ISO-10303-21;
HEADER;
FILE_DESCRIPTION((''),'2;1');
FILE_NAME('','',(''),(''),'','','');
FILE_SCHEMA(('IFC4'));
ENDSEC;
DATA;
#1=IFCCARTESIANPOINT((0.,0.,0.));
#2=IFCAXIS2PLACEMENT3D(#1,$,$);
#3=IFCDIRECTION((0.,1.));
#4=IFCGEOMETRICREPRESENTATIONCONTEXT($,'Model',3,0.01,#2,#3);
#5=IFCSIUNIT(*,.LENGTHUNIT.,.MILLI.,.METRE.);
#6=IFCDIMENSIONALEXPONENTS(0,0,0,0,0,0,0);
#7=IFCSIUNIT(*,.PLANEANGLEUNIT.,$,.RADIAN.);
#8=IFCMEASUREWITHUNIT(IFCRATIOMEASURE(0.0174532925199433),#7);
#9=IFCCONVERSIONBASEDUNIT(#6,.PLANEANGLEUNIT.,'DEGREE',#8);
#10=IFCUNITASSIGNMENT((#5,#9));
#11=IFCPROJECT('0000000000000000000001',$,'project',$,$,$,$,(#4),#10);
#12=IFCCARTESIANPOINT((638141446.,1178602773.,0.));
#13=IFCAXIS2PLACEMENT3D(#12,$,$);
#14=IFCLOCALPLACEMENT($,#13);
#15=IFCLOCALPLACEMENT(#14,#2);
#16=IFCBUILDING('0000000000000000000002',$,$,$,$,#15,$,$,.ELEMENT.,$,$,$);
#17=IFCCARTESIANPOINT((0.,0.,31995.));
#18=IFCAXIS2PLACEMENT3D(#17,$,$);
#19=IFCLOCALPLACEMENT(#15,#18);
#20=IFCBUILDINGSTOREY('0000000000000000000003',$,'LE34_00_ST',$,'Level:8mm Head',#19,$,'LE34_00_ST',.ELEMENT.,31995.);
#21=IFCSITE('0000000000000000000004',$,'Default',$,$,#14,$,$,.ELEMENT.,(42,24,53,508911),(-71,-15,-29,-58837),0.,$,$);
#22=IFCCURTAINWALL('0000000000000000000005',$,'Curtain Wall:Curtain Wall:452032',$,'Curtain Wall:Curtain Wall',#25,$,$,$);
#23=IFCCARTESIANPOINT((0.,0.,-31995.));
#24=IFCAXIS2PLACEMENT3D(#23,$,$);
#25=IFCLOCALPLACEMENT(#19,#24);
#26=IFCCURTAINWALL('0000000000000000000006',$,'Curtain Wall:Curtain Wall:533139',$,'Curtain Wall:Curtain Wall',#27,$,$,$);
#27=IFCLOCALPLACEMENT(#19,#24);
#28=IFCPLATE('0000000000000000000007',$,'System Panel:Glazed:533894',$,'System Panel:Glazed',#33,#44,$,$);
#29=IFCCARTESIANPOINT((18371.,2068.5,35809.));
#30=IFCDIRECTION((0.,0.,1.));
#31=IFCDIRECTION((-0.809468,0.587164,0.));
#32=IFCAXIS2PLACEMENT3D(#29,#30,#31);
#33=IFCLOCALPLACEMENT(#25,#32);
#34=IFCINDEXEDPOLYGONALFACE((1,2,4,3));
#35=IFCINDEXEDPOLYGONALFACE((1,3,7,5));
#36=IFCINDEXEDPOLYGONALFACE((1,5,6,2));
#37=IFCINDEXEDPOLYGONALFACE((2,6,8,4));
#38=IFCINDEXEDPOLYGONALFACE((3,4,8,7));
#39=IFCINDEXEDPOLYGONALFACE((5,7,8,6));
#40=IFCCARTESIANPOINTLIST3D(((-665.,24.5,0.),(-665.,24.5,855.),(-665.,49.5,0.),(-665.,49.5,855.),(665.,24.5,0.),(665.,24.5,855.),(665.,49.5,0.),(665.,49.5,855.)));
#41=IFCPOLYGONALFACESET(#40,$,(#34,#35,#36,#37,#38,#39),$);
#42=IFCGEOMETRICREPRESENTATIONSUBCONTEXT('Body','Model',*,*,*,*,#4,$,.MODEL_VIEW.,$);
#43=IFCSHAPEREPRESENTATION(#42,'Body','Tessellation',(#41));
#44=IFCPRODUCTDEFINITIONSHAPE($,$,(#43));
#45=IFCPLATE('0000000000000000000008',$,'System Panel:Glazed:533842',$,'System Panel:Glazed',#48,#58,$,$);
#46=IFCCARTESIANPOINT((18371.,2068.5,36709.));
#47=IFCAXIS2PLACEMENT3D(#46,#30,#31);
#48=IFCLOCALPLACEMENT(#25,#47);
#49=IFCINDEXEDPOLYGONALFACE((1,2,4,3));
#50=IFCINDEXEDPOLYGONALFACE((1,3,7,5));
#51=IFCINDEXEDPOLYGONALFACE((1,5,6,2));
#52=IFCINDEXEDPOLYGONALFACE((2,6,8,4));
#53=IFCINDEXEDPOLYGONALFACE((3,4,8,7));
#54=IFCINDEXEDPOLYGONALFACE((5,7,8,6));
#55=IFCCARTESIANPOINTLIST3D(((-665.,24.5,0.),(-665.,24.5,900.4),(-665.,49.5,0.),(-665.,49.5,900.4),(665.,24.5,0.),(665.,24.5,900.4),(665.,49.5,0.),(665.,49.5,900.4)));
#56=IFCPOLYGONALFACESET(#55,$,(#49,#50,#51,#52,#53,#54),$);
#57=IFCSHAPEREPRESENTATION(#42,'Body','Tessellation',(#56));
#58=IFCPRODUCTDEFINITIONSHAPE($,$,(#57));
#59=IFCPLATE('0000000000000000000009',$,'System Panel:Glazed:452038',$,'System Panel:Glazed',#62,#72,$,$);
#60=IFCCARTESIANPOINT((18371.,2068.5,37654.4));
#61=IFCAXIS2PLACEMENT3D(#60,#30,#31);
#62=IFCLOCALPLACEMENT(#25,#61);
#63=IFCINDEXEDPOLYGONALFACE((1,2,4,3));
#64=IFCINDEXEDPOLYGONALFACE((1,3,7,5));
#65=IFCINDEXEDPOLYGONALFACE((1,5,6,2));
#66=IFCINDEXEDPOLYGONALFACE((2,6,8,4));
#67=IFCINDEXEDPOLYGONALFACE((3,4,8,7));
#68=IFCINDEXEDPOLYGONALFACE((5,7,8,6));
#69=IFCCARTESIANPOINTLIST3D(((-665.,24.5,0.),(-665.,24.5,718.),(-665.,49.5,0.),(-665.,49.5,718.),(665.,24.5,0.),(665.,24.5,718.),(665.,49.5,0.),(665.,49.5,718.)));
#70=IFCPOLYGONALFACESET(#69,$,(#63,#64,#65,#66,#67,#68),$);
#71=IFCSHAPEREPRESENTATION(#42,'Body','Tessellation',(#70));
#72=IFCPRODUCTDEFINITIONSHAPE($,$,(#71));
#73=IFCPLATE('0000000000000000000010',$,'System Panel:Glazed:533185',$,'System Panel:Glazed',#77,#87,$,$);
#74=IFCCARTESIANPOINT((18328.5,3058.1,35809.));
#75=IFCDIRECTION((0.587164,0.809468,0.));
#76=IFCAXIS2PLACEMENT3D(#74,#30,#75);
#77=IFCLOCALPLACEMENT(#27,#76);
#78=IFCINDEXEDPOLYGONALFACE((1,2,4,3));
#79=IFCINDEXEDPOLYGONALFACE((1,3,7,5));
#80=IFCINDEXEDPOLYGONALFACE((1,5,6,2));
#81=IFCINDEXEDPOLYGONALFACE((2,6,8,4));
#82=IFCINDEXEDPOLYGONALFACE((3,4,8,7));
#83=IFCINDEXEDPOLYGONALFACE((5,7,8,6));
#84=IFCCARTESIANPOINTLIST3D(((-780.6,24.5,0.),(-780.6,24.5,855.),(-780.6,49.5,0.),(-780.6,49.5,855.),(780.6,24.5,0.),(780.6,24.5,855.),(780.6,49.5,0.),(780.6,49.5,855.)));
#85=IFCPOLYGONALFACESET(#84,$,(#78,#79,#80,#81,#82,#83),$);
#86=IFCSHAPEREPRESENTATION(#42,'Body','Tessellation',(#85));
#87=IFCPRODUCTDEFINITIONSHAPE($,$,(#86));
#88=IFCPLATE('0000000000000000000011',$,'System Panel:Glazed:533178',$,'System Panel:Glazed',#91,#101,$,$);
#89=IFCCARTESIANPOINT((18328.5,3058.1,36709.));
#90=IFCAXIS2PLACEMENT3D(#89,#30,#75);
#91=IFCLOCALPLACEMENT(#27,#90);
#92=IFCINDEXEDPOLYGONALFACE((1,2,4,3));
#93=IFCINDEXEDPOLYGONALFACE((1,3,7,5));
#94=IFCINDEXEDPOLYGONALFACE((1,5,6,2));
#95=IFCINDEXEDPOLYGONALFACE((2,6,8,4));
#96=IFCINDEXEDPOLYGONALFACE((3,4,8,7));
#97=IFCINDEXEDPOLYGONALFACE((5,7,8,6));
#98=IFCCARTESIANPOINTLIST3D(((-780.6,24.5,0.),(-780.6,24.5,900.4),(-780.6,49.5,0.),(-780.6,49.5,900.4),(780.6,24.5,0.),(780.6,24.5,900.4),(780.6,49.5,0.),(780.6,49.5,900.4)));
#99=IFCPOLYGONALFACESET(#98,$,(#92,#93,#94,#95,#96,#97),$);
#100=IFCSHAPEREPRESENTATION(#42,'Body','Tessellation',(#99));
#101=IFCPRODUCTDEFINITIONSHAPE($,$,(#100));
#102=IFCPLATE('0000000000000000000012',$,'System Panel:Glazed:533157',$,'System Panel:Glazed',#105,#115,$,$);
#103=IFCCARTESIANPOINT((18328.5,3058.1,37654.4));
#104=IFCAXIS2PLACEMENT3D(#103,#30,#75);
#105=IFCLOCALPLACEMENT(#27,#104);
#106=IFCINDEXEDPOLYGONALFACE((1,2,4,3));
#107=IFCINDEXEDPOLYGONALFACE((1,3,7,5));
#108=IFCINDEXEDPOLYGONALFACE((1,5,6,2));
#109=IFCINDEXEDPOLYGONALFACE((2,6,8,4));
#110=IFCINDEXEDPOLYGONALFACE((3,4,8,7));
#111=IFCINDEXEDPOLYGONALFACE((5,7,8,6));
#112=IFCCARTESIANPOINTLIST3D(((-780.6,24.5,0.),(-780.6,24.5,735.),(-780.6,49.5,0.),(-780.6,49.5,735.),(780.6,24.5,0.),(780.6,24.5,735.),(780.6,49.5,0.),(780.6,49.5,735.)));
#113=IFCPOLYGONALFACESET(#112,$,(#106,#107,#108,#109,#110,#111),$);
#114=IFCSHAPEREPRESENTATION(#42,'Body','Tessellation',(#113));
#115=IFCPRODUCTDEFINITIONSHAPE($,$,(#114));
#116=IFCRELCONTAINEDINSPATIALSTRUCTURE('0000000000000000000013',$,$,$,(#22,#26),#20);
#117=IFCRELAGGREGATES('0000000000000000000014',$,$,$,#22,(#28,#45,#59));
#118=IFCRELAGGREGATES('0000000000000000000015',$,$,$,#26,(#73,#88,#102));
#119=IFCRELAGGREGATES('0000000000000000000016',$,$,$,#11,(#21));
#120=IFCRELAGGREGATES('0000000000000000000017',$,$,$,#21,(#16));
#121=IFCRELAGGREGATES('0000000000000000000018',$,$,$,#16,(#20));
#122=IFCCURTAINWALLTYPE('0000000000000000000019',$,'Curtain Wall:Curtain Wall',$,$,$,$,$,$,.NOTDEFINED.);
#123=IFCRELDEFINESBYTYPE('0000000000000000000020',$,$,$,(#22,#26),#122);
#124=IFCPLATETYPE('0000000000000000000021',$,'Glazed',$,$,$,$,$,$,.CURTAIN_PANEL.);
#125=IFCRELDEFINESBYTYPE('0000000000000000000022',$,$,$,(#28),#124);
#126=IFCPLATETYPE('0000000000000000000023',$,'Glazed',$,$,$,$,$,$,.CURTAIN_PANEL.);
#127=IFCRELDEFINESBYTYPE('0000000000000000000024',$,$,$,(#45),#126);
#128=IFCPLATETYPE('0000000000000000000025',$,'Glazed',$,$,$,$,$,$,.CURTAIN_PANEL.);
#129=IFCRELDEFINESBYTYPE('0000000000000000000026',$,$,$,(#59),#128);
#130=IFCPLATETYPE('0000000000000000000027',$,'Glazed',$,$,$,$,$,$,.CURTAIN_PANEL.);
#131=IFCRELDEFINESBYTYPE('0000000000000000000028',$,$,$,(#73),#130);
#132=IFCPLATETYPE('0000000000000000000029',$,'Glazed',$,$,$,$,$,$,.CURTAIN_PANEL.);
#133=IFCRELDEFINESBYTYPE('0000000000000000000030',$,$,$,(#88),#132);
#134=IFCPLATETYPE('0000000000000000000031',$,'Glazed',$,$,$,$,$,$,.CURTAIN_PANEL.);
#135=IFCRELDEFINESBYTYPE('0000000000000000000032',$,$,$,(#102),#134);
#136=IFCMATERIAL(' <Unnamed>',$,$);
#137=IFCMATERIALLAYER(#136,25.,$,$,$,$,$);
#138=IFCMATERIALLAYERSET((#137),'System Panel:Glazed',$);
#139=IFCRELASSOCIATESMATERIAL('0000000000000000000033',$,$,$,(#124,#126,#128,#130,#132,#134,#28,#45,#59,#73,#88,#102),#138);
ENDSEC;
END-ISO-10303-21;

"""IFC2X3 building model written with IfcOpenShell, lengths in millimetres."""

from ifc_helpers import new_model, entity, si_unit, converted_unit, direction, frame, origin, origin_2d_with_axis, place, context, subcontext, project, spatial, rectangle, extrude, source, transform, mapped, material, layer, layer_set, layer_usage, type_object, type_shapes, element, aggregate, save


model = new_model("IFC2X3")

# Units and contexts
model_context = context("Model", 3, precision=0.01, world=origin(), true_north=direction((0.0, 1.0)))
body_context = subcontext(model_context, "Body", "Model", "MODEL_VIEW")
ifc_project = project(units=[si_unit("LENGTHUNIT", "METRE", prefix="MILLI"), converted_unit("PLANEANGLEUNIT", "DEGREE", entity("IfcRatioMeasure", 0.0174532925199433), si_unit("PLANEANGLEUNIT", "RADIAN"), dimensions=[0, 0, 0, 0, 0, 0, 0])], contexts=[model_context])

# Site, building, storey
site_placement = place(None, frame((638141446.0, 1178602773.0, 0.0)))
site = spatial("IfcSite", under=ifc_project, at=site_placement, Name="Default", CompositionType="ELEMENT", RefLatitude=(42, 24, 53, 508911), RefLongitude=(-71, -15, -29, -58837), RefElevation=0.0)
building_placement = place(site_placement, origin())
building = spatial("IfcBuilding", under=site, at=building_placement, CompositionType="ELEMENT")
storey_placement = place(building_placement, frame((0.0, 0.0, 31995.0)))
storey = spatial("IfcBuildingStorey", under=building, at=storey_placement, Name="LE34_00_ST", ObjectType="Level:8mm Head", LongName="LE34_00_ST", CompositionType="ELEMENT", Elevation=31995.0)

# Shared definitions
curtain_wall_type = type_object("IfcCurtainWallType", Name="Curtain Wall:Curtain Wall", PredefinedType="NOTDEFINED")

# Curtain walls
curtain_wall_1_placement = place(storey_placement, frame((0.0, 0.0, -31995.0)))
curtain_wall_1 = element("IfcCurtainWall", 1, at=curtain_wall_1_placement, inside=storey, type_object=curtain_wall_type, Name="Curtain Wall:Curtain Wall:452032", ObjectType="Curtain Wall:Curtain Wall")
curtain_wall_2_placement = place(storey_placement, frame((0.0, 0.0, -31995.0)))
curtain_wall_2 = element("IfcCurtainWall", 2, at=curtain_wall_2_placement, inside=storey, type_object=curtain_wall_type, Name="Curtain Wall:Curtain Wall:533139", ObjectType="Curtain Wall:Curtain Wall")

# Plates
ifc_material_1 = material(Name=" <Unnamed>")
ifc_layer = layer(ifc_material_1, 25.0)
ifc_layer_set = layer_set([ifc_layer], Name="System Panel:Glazed")
ifc_layer_usage_1 = layer_usage(ifc_layer_set, "AXIS3", "POSITIVE", 0.1)
plate_type_1 = type_object("IfcPlateType", Name="Glazed", PredefinedType="CURTAIN_PANEL", material=ifc_layer_set)
shared_shape_1 = source(origin(), body_context, "Body", "SweptSolid", [
    extrude(rectangle(XDim=25.0, YDim=1330.0, at=origin_2d_with_axis()), frame((0.0, 37.0, 0.0), z_axis=(0.0, 0.0, 1.0), x_axis=(0.0, 1.0, 0.0)), (0.0, 0.0, 1.0), 855.0),
])
type_shapes(plate_type_1, [shared_shape_1])
plate_1_placement = place(curtain_wall_1_placement, frame((18371.0, 2068.5, 35809.0), z_axis=(0.0, 0.0, 1.0), x_axis=(-0.809468, 0.587164, 0.0)))
plate_1 = element("IfcPlate", 3, at=plate_1_placement, type_object=plate_type_1, material=ifc_layer_usage_1, Name="System Panel:Glazed:533894", ObjectType="System Panel:Glazed", context=body_context, shape_type="MappedRepresentation", body=[
    mapped(shared_shape_1, transform((0.0, 0.0, 0.0), scale=1.0)),
])
ifc_layer_usage_2 = layer_usage(ifc_layer_set, "AXIS3", "POSITIVE", 0.1)
plate_type_2 = type_object("IfcPlateType", Name="Glazed", PredefinedType="CURTAIN_PANEL", material=ifc_layer_set)
shared_shape_2 = source(origin(), body_context, "Body", "SweptSolid", [
    extrude(rectangle(XDim=25.0, YDim=1330.0, at=origin_2d_with_axis()), frame((0.0, 37.0, 0.0), z_axis=(0.0, 0.0, 1.0), x_axis=(0.0, 1.0, 0.0)), (0.0, 0.0, 1.0), 900.4),
])
type_shapes(plate_type_2, [shared_shape_2])
plate_2_placement = place(curtain_wall_1_placement, frame((18371.0, 2068.5, 36709.0), z_axis=(0.0, 0.0, 1.0), x_axis=(-0.809468, 0.587164, 0.0)))
plate_2 = element("IfcPlate", 4, at=plate_2_placement, type_object=plate_type_2, material=ifc_layer_usage_2, Name="System Panel:Glazed:533842", ObjectType="System Panel:Glazed", context=body_context, shape_type="MappedRepresentation", body=[
    mapped(shared_shape_2, transform((0.0, 0.0, 0.0), scale=1.0)),
])
ifc_layer_usage_3 = layer_usage(ifc_layer_set, "AXIS3", "POSITIVE", 0.1)
plate_type_3 = type_object("IfcPlateType", Name="Glazed", PredefinedType="CURTAIN_PANEL", material=ifc_layer_set)
shared_shape_3 = source(origin(), body_context, "Body", "SweptSolid", [
    extrude(rectangle(XDim=25.0, YDim=1330.0, at=origin_2d_with_axis()), frame((0.0, 37.0, 0.0), z_axis=(0.0, 0.0, 1.0), x_axis=(0.0, 1.0, 0.0)), (0.0, 0.0, 1.0), 718.0),
])
type_shapes(plate_type_3, [shared_shape_3])
plate_3_placement = place(curtain_wall_1_placement, frame((18371.0, 2068.5, 37654.4), z_axis=(0.0, 0.0, 1.0), x_axis=(-0.809468, 0.587164, 0.0)))
plate_3 = element("IfcPlate", 5, at=plate_3_placement, type_object=plate_type_3, material=ifc_layer_usage_3, Name="System Panel:Glazed:452038", ObjectType="System Panel:Glazed", context=body_context, shape_type="MappedRepresentation", body=[
    mapped(shared_shape_3, transform((0.0, 0.0, 0.0), scale=1.0)),
])
aggregate(curtain_wall_1, [plate_1, plate_2, plate_3])
ifc_layer_usage_4 = layer_usage(ifc_layer_set, "AXIS3", "POSITIVE", 0.1)
plate_type_4 = type_object("IfcPlateType", Name="Glazed", PredefinedType="CURTAIN_PANEL", material=ifc_layer_set)
shared_shape_4 = source(origin(), body_context, "Body", "SweptSolid", [
    extrude(rectangle(XDim=25.0, YDim=1561.3, at=origin_2d_with_axis()), frame((0.0, 37.0, 0.0), z_axis=(0.0, 0.0, 1.0), x_axis=(0.0, 1.0, 0.0)), (0.0, 0.0, 1.0), 855.0),
])
type_shapes(plate_type_4, [shared_shape_4])
plate_4_placement = place(curtain_wall_2_placement, frame((18328.5, 3058.1, 35809.0), z_axis=(0.0, 0.0, 1.0), x_axis=(0.587164, 0.809468, 0.0)))
plate_4 = element("IfcPlate", 6, at=plate_4_placement, type_object=plate_type_4, material=ifc_layer_usage_4, Name="System Panel:Glazed:533185", ObjectType="System Panel:Glazed", context=body_context, shape_type="MappedRepresentation", body=[
    mapped(shared_shape_4, transform((0.0, 0.0, 0.0), scale=1.0)),
])
ifc_layer_usage_5 = layer_usage(ifc_layer_set, "AXIS3", "POSITIVE", 0.1)
plate_type_5 = type_object("IfcPlateType", Name="Glazed", PredefinedType="CURTAIN_PANEL", material=ifc_layer_set)
shared_shape_5 = source(origin(), body_context, "Body", "SweptSolid", [
    extrude(rectangle(XDim=25.0, YDim=1561.3, at=origin_2d_with_axis()), frame((0.0, 37.0, 0.0), z_axis=(0.0, 0.0, 1.0), x_axis=(0.0, 1.0, 0.0)), (0.0, 0.0, 1.0), 900.4),
])
type_shapes(plate_type_5, [shared_shape_5])
plate_5_placement = place(curtain_wall_2_placement, frame((18328.5, 3058.1, 36709.0), z_axis=(0.0, 0.0, 1.0), x_axis=(0.587164, 0.809468, 0.0)))
plate_5 = element("IfcPlate", 7, at=plate_5_placement, type_object=plate_type_5, material=ifc_layer_usage_5, Name="System Panel:Glazed:533178", ObjectType="System Panel:Glazed", context=body_context, shape_type="MappedRepresentation", body=[
    mapped(shared_shape_5, transform((0.0, 0.0, 0.0), scale=1.0)),
])
ifc_layer_usage_6 = layer_usage(ifc_layer_set, "AXIS3", "POSITIVE", 0.1)
plate_type_6 = type_object("IfcPlateType", Name="Glazed", PredefinedType="CURTAIN_PANEL", material=ifc_layer_set)
shared_shape_6 = source(origin(), body_context, "Body", "SweptSolid", [
    extrude(rectangle(XDim=25.0, YDim=1561.3, at=origin_2d_with_axis()), frame((0.0, 37.0, 0.0), z_axis=(0.0, 0.0, 1.0), x_axis=(0.0, 1.0, 0.0)), (0.0, 0.0, 1.0), 735.0),
])
type_shapes(plate_type_6, [shared_shape_6])
plate_6_placement = place(curtain_wall_2_placement, frame((18328.5, 3058.1, 37654.4), z_axis=(0.0, 0.0, 1.0), x_axis=(0.587164, 0.809468, 0.0)))
plate_6 = element("IfcPlate", 8, at=plate_6_placement, type_object=plate_type_6, material=ifc_layer_usage_6, Name="System Panel:Glazed:533157", ObjectType="System Panel:Glazed", context=body_context, shape_type="MappedRepresentation", body=[
    mapped(shared_shape_6, transform((0.0, 0.0, 0.0), scale=1.0)),
])
aggregate(curtain_wall_2, [plate_4, plate_5, plate_6])

save(model, "model.ifc")
